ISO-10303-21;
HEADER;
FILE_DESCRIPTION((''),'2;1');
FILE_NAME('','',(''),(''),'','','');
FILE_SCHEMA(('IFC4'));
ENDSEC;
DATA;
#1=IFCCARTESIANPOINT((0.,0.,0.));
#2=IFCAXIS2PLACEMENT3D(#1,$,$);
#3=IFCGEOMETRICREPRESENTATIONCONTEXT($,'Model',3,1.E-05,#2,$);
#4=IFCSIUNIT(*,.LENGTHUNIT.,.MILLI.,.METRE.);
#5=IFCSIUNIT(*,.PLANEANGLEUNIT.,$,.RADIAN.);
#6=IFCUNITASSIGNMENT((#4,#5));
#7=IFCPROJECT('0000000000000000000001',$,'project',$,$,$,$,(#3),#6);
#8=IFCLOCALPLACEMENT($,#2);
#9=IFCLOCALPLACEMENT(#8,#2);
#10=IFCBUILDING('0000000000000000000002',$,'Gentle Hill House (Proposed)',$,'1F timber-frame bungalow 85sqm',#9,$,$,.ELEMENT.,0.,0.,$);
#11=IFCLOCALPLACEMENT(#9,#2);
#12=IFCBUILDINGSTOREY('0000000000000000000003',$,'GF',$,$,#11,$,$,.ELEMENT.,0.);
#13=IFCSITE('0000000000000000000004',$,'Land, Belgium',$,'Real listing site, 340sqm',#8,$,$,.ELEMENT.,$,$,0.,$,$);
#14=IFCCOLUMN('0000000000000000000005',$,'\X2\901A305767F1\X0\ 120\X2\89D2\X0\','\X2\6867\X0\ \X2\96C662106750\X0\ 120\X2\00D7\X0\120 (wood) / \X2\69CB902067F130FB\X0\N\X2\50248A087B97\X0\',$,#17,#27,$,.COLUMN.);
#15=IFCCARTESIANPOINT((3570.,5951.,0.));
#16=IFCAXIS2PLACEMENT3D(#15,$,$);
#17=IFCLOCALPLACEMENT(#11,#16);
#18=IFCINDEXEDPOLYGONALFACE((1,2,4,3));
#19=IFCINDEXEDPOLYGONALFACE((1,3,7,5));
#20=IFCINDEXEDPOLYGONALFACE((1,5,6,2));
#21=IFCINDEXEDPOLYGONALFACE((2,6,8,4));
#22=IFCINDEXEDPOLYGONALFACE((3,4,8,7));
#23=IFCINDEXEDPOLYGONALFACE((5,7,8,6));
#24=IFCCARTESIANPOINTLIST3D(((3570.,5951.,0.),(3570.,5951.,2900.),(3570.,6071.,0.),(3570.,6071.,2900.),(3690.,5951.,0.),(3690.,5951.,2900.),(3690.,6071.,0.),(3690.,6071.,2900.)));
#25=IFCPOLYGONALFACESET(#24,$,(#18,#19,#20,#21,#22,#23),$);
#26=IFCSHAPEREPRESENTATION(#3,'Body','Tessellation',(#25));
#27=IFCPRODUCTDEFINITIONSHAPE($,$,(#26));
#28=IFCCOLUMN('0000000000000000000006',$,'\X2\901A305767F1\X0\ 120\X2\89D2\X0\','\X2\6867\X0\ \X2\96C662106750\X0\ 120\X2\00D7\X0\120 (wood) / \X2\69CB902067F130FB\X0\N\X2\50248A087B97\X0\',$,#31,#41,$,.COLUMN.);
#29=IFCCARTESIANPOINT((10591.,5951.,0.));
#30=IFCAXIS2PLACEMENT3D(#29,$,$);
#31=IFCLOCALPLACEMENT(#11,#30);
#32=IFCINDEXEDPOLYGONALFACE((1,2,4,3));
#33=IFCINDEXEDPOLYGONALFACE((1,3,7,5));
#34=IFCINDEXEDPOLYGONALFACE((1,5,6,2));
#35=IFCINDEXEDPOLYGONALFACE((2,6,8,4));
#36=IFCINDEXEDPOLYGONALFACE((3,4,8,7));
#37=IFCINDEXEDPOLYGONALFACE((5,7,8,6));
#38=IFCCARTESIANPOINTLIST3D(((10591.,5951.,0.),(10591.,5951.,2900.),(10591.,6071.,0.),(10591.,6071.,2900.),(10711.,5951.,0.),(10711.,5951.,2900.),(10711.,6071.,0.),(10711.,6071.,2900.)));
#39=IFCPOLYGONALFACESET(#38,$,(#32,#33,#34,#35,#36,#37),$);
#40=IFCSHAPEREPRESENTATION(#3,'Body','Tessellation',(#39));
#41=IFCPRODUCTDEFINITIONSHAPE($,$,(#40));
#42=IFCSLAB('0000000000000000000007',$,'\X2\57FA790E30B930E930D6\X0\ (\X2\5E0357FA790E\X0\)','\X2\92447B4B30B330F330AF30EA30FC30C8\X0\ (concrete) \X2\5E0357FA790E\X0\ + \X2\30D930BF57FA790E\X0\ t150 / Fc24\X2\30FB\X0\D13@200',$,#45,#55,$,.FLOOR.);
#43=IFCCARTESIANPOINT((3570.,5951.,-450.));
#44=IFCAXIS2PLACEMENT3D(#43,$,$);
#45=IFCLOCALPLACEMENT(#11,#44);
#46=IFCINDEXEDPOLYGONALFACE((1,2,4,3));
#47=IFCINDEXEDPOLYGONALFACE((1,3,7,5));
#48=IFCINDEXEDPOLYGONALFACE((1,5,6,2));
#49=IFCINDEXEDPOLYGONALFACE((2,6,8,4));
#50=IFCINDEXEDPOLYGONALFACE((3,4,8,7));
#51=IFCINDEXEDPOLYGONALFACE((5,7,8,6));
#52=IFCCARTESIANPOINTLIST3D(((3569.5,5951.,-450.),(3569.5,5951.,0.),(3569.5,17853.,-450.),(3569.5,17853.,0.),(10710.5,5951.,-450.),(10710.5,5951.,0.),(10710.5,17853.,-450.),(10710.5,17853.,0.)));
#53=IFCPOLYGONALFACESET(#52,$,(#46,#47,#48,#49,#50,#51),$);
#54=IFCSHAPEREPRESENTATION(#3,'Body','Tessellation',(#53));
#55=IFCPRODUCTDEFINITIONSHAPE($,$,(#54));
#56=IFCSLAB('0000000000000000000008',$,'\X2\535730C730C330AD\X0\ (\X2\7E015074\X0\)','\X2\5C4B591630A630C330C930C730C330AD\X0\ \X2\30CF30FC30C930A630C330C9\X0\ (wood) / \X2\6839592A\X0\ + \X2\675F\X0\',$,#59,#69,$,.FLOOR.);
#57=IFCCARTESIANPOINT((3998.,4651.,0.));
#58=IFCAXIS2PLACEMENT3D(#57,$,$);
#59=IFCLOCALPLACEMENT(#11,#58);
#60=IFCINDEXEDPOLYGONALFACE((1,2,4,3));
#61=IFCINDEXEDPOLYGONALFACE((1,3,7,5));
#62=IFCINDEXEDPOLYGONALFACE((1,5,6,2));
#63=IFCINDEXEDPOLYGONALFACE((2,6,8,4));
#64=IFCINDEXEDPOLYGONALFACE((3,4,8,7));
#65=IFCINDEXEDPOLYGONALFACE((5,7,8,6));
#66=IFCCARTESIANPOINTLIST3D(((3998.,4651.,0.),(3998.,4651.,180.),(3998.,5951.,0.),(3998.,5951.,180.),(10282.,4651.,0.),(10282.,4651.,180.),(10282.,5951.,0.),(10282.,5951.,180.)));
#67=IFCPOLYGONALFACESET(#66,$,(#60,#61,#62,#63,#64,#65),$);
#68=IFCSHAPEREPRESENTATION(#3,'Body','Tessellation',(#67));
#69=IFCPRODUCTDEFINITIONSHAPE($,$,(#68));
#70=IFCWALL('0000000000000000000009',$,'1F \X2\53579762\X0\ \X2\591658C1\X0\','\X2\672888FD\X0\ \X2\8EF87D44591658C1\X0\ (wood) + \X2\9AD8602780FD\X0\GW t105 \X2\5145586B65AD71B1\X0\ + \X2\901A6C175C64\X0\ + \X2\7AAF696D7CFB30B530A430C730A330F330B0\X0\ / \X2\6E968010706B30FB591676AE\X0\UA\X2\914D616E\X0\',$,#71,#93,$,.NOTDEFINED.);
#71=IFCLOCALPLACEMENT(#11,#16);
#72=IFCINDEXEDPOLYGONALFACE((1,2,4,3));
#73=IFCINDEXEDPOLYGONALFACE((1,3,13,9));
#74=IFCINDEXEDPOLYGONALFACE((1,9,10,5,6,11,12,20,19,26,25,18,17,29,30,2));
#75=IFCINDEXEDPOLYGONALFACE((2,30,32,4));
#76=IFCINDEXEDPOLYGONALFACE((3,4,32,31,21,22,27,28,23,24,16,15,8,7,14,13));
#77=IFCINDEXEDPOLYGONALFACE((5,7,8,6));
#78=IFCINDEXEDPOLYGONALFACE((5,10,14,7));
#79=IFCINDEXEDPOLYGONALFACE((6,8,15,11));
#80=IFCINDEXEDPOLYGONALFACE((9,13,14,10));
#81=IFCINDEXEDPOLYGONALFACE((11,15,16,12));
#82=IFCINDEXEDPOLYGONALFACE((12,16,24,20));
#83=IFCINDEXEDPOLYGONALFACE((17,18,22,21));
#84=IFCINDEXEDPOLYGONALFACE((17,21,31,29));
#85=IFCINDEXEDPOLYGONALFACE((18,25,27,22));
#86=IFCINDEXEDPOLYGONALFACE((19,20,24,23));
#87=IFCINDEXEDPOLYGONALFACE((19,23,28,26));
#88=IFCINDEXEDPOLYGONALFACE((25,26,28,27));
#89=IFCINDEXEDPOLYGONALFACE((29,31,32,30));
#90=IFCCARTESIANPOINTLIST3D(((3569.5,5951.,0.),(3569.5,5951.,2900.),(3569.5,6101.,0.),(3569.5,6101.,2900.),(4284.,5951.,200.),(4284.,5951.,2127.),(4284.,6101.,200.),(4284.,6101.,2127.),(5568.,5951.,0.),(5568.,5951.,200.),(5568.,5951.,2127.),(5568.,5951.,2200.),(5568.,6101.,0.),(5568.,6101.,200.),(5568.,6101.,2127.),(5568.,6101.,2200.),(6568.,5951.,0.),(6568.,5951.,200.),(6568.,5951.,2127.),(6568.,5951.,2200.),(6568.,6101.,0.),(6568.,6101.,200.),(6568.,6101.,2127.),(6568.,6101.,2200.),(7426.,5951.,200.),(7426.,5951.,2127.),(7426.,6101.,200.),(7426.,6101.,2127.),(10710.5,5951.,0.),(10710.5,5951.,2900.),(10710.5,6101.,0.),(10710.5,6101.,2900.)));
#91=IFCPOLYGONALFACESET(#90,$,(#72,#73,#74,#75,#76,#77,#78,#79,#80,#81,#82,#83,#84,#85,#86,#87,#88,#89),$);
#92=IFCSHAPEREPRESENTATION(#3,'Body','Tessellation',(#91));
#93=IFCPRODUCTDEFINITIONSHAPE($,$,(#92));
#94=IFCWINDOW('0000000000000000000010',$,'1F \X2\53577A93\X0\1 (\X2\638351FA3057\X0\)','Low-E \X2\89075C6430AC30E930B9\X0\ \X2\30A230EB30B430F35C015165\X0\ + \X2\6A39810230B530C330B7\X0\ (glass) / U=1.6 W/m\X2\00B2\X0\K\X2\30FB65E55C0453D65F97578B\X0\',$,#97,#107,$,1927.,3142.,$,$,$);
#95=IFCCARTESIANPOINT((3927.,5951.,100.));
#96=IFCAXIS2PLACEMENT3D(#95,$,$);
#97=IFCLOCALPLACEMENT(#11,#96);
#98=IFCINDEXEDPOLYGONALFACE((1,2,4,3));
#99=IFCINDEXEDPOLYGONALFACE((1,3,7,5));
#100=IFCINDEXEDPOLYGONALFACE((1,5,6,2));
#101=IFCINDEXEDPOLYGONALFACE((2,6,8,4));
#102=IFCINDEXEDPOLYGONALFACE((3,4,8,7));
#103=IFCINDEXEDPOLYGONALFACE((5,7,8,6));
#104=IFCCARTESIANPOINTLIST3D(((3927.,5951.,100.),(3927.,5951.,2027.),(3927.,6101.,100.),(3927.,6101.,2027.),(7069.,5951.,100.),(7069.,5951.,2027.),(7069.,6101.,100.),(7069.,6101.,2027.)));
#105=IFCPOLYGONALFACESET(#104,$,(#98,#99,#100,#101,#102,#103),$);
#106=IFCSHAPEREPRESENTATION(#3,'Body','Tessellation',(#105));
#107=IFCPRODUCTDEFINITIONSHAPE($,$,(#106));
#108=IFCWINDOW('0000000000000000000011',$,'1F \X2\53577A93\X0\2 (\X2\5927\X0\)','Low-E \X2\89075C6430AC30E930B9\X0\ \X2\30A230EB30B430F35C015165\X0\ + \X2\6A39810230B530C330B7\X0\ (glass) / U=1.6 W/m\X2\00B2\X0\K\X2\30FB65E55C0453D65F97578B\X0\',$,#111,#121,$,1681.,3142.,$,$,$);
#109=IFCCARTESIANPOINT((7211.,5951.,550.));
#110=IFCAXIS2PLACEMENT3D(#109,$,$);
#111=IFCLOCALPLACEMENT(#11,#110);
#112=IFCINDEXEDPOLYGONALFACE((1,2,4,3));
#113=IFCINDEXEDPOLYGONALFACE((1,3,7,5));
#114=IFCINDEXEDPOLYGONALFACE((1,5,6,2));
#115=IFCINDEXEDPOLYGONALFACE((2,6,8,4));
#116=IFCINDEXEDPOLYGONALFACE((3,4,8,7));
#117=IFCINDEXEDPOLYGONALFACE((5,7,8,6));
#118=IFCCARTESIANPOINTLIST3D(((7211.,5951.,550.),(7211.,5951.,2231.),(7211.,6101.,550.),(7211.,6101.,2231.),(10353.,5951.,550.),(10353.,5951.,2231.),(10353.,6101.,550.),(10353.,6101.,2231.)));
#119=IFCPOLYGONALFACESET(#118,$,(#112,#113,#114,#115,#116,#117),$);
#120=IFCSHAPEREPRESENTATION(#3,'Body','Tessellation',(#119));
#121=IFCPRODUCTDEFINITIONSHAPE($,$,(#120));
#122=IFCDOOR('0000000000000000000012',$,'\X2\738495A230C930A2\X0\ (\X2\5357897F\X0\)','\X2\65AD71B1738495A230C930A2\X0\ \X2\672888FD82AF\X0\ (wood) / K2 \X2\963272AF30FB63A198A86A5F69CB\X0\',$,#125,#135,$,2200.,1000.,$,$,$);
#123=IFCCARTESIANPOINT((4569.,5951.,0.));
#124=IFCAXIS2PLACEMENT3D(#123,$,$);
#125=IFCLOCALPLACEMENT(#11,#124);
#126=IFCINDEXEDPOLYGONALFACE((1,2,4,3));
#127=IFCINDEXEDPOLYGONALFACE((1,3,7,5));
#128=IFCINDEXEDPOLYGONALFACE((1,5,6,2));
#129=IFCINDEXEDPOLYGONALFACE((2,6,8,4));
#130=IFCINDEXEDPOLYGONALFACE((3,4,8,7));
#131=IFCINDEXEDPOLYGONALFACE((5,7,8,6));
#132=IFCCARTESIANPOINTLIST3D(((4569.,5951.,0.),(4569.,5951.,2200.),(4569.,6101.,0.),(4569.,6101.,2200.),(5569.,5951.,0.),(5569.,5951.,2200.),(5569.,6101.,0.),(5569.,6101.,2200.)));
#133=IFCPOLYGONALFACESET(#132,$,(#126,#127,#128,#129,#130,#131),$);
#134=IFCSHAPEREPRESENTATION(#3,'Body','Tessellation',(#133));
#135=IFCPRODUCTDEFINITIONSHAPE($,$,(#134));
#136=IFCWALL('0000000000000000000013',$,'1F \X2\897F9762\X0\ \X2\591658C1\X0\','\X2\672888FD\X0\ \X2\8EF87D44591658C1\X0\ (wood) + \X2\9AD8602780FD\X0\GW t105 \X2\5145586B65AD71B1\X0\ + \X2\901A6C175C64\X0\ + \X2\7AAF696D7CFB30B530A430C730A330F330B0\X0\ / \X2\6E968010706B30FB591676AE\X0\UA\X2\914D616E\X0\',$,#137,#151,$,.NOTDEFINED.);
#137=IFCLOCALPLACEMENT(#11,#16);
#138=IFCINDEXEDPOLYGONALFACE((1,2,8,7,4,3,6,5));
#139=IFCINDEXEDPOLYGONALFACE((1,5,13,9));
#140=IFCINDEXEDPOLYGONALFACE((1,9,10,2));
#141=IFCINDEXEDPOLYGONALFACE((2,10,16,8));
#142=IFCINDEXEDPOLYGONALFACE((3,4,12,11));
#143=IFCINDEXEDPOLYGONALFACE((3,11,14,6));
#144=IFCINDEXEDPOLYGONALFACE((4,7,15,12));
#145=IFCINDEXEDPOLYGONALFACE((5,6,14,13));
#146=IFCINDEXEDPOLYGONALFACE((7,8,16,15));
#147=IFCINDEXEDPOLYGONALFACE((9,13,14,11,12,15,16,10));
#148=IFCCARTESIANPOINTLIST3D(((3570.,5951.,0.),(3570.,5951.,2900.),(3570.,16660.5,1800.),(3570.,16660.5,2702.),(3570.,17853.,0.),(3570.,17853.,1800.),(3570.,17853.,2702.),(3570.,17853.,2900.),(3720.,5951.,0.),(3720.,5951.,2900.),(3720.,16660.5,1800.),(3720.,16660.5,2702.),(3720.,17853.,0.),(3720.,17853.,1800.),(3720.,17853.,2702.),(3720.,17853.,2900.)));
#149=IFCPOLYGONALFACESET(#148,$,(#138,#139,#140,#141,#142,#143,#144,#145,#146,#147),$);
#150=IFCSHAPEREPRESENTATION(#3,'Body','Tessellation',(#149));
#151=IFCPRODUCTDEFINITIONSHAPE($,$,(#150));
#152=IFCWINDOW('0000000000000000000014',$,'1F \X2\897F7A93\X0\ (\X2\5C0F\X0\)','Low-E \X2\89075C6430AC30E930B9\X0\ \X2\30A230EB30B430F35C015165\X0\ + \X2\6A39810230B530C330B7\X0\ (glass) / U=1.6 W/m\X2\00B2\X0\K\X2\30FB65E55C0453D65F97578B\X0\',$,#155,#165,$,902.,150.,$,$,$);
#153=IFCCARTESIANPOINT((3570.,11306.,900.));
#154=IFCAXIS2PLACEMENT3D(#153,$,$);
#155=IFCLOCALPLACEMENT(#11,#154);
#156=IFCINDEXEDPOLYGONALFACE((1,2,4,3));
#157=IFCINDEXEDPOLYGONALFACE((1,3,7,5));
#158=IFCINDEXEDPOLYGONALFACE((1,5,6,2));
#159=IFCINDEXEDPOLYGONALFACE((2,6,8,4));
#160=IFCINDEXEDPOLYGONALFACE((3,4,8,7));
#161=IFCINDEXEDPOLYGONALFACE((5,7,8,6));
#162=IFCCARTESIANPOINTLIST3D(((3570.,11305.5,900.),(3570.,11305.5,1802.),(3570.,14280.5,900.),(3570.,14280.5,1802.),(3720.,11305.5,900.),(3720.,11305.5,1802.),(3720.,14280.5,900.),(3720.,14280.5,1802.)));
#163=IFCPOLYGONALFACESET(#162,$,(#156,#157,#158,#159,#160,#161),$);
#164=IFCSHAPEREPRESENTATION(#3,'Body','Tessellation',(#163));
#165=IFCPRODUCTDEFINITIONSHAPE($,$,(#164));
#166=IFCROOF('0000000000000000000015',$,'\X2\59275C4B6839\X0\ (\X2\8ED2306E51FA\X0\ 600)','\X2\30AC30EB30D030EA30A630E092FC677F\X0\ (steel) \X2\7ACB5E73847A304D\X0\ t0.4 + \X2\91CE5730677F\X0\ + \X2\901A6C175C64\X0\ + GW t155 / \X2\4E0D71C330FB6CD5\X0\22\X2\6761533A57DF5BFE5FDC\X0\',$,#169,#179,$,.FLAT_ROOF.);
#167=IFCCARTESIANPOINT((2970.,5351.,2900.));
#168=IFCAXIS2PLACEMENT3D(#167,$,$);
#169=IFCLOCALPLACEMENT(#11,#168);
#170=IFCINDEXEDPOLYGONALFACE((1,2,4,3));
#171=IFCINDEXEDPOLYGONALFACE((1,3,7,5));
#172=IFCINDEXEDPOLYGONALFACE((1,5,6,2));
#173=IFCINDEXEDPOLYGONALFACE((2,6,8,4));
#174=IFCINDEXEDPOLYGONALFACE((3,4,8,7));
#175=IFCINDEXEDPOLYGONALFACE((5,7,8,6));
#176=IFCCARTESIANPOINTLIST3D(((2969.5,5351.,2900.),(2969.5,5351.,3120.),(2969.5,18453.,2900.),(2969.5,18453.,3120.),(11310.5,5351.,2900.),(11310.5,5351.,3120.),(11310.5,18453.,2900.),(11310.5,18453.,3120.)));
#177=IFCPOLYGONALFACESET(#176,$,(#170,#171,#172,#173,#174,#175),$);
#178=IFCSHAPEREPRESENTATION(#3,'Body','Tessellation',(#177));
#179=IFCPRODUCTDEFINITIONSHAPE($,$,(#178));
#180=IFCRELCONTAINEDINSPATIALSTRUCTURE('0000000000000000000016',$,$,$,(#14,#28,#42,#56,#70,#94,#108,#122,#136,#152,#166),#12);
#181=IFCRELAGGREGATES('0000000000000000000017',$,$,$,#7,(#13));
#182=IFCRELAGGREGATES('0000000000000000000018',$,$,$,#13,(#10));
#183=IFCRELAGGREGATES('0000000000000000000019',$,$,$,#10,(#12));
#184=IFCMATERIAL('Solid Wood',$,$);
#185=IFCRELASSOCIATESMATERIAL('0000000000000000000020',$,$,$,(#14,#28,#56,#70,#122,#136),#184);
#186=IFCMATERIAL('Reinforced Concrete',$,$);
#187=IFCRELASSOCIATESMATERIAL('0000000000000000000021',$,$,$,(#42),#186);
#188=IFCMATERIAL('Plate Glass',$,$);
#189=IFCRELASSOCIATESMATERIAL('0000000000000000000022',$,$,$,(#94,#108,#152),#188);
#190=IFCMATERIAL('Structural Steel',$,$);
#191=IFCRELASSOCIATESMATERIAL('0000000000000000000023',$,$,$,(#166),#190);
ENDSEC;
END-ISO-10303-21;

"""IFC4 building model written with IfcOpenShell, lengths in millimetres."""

from ifc_helpers import new_model, si_unit, frame, frame_2d, origin, place, context, project, spatial, rectangle, extrude, material, element, fill, save


model = new_model("IFC4")

# Units and contexts
model_context = context("Model", 3, precision=1e-05, world=origin())
ifc_project = project(units=[si_unit("LENGTHUNIT", "METRE", prefix="MILLI"), si_unit("PLANEANGLEUNIT", "RADIAN")], contexts=[model_context])

# Site, building, storey
site_placement = place(None, origin())
site = spatial("IfcSite", under=ifc_project, at=site_placement, Name="Land, Belgium", ObjectType="Real listing site, 340sqm", CompositionType="ELEMENT", RefElevation=0.0)
building_placement = place(site_placement, origin())
building = spatial("IfcBuilding", under=site, at=building_placement, Name="Gentle Hill House (Proposed)", ObjectType="1F timber-frame bungalow 85sqm", CompositionType="ELEMENT", ElevationOfRefHeight=0.0, ElevationOfTerrain=0.0)
storey_placement = place(building_placement, origin())
storey = spatial("IfcBuildingStorey", under=building, at=storey_placement, Name="GF", CompositionType="ELEMENT", Elevation=0.0)

# Columns
ifc_material_1 = material(Name="Solid Wood")
column_1_placement = place(storey_placement, frame((3570.0, 5951.0, 0.0)))
element("IfcColumn", 1, at=column_1_placement, inside=storey, material=ifc_material_1, Name="通し柱 120角", Description="桧 集成材 120×120 (wood) / 構造柱・N値計算", PredefinedType="COLUMN", context=model_context, shape_type="SweptSolid", body=[
    extrude(rectangle(XDim=120.0, YDim=120.0, at=frame_2d((60.0, 60.0))), frame((3570.0, 5951.0, 0.0)), (0.0, 0.0, 1.0), 2900.0),
])
column_2_placement = place(storey_placement, frame((10591.0, 5951.0, 0.0)))
element("IfcColumn", 2, at=column_2_placement, inside=storey, material=ifc_material_1, Name="通し柱 120角", Description="桧 集成材 120×120 (wood) / 構造柱・N値計算", PredefinedType="COLUMN", context=model_context, shape_type="SweptSolid", body=[
    extrude(rectangle(XDim=120.0, YDim=120.0, at=frame_2d((60.0, 60.0))), frame((10591.0, 5951.0, 0.0)), (0.0, 0.0, 1.0), 2900.0),
])

# Slabs
ifc_material_2 = material(Name="Reinforced Concrete")
slab_1_placement = place(storey_placement, frame((3570.0, 5951.0, -450.0)))
element("IfcSlab", 3, at=slab_1_placement, inside=storey, material=ifc_material_2, Name="基礎スラブ (布基礎)", Description="鉄筋コンクリート (concrete) 布基礎 + ベタ基礎 t150 / Fc24・D13@200", PredefinedType="FLOOR", context=model_context, shape_type="SweptSolid", body=[
    extrude(rectangle(XDim=7141.0, YDim=11902.0, at=frame_2d((3570.0, 5951.0))), frame((3570.0, 5951.0, -450.0)), (0.0, 0.0, 1.0), 450.0),
])
slab_2_placement = place(storey_placement, frame((3998.0, 4651.0, 0.0)))
element("IfcSlab", 4, at=slab_2_placement, inside=storey, material=ifc_material_1, Name="南デッキ (縁側)", Description="屋外ウッドデッキ ハードウッド (wood) / 根太 + 束", PredefinedType="FLOOR", context=model_context, shape_type="SweptSolid", body=[
    extrude(rectangle(XDim=6284.0, YDim=1300.0, at=frame_2d((3142.0, 650.0))), frame((3998.0, 4651.0, 0.0)), (0.0, 0.0, 1.0), 180.0),
])

# Wall, openings, windows, door
wall_1_placement = place(storey_placement, frame((3570.0, 5951.0, 0.0)))
wall_1 = element("IfcWall", 5, at=wall_1_placement, inside=storey, material=ifc_material_1, Name="1F 南面 外壁", Description="木製 軸組外壁 (wood) + 高性能GW t105 充填断熱 + 通気層 + 窯業系サイディング / 準耐火・外皮UA配慮", PredefinedType="NOTDEFINED", context=model_context, shape_type="SweptSolid", body=[
    extrude(rectangle(XDim=7141.0, YDim=150.0, at=frame_2d((3570.0, 75.0))), frame((3570.0, 5951.0, 0.0)), (0.0, 0.0, 1.0), 2900.0),
])
opening_1_placement = place(storey_placement, frame((3927.0, 5951.0, 100.0)))
opening_1 = element("IfcOpeningElement", 6, at=opening_1_placement, cuts=wall_1, PredefinedType="NOTDEFINED", context=model_context, shape_type="SweptSolid", body=[
    extrude(rectangle(XDim=3142.0, YDim=150.0, at=frame_2d((1571.0, 75.0))), frame((3927.0, 5951.0, 100.0)), (0.0, 0.0, 1.0), 1927.0),
])
opening_2_placement = place(storey_placement, frame((7211.0, 5951.0, 550.0)))
opening_2 = element("IfcOpeningElement", 7, at=opening_2_placement, cuts=wall_1, PredefinedType="NOTDEFINED", context=model_context, shape_type="SweptSolid", body=[
    extrude(rectangle(XDim=3142.0, YDim=150.0, at=frame_2d((1571.0, 75.0))), frame((7211.0, 5951.0, 550.0)), (0.0, 0.0, 1.0), 1681.0),
])
opening_3_placement = place(storey_placement, frame((4569.0, 5951.0, 0.0)))
opening_3 = element("IfcOpeningElement", 8, at=opening_3_placement, cuts=wall_1, PredefinedType="NOTDEFINED", context=model_context, shape_type="SweptSolid", body=[
    extrude(rectangle(XDim=1000.0, YDim=150.0, at=frame_2d((500.0, 75.0))), frame((4569.0, 5951.0, 0.0)), (0.0, 0.0, 1.0), 2200.0),
])
ifc_material_3 = material(Name="Plate Glass")
window_1_placement = place(storey_placement, frame((3927.0, 5951.0, 100.0)))
window_1 = element("IfcWindow", 9, at=window_1_placement, inside=storey, material=ifc_material_3, Name="1F 南窓1 (掃出し)", Description="Low-E 複層ガラス アルゴン封入 + 樹脂サッシ (glass) / U=1.6 W/m²K・日射取得型", OverallHeight=1927.0, OverallWidth=3142.0, context=model_context, shape_type="SweptSolid", body=[
    extrude(rectangle(XDim=3142.0, YDim=150.0, at=frame_2d((1571.0, 75.0))), frame((3927.0, 5951.0, 100.0)), (0.0, 0.0, 1.0), 1927.0),
])
fill(opening_1, window_1)
window_2_placement = place(storey_placement, frame((7211.0, 5951.0, 550.0)))
window_2 = element("IfcWindow", 10, at=window_2_placement, inside=storey, material=ifc_material_3, Name="1F 南窓2 (大)", Description="Low-E 複層ガラス アルゴン封入 + 樹脂サッシ (glass) / U=1.6 W/m²K・日射取得型", OverallHeight=1681.0, OverallWidth=3142.0, context=model_context, shape_type="SweptSolid", body=[
    extrude(rectangle(XDim=3142.0, YDim=150.0, at=frame_2d((1571.0, 75.0))), frame((7211.0, 5951.0, 550.0)), (0.0, 0.0, 1.0), 1681.0),
])
fill(opening_2, window_2)
door_placement = place(storey_placement, frame((4569.0, 5951.0, 0.0)))
door = element("IfcDoor", 11, at=door_placement, inside=storey, material=ifc_material_1, Name="玄関ドア (南西)", Description="断熱玄関ドア 木製芯 (wood) / K2 防犯・採風機構", OverallHeight=2200.0, OverallWidth=1000.0, context=model_context, shape_type="SweptSolid", body=[
    extrude(rectangle(XDim=1000.0, YDim=150.0, at=frame_2d((500.0, 75.0))), frame((4569.0, 5951.0, 0.0)), (0.0, 0.0, 1.0), 2200.0),
])
fill(opening_3, door)

# Wall, opening, window
wall_2_placement = place(storey_placement, frame((3570.0, 5951.0, 0.0)))
wall_2 = element("IfcWall", 12, at=wall_2_placement, inside=storey, material=ifc_material_1, Name="1F 西面 外壁", Description="木製 軸組外壁 (wood) + 高性能GW t105 充填断熱 + 通気層 + 窯業系サイディング / 準耐火・外皮UA配慮", PredefinedType="NOTDEFINED", context=model_context, shape_type="SweptSolid", body=[
    extrude(rectangle(XDim=150.0, YDim=11902.0, at=frame_2d((75.0, 5951.0))), frame((3570.0, 5951.0, 0.0)), (0.0, 0.0, 1.0), 2900.0),
])
opening_4_placement = place(storey_placement, frame((3570.0, 11306.0, 900.0)))
opening_4 = element("IfcOpeningElement", 13, at=opening_4_placement, cuts=wall_2, PredefinedType="NOTDEFINED", context=model_context, shape_type="SweptSolid", body=[
    extrude(rectangle(XDim=150.0, YDim=2975.0, at=frame_2d((75.0, 1487.0))), frame((3570.0, 11306.0, 900.0)), (0.0, 0.0, 1.0), 902.0),
])
window_3_placement = place(storey_placement, frame((3570.0, 11306.0, 900.0)))
window_3 = element("IfcWindow", 14, at=window_3_placement, inside=storey, material=ifc_material_3, Name="1F 西窓 (小)", Description="Low-E 複層ガラス アルゴン封入 + 樹脂サッシ (glass) / U=1.6 W/m²K・日射取得型", OverallHeight=902.0, OverallWidth=150.0, context=model_context, shape_type="SweptSolid", body=[
    extrude(rectangle(XDim=150.0, YDim=2975.0, at=frame_2d((75.0, 1487.0))), frame((3570.0, 11306.0, 900.0)), (0.0, 0.0, 1.0), 902.0),
])
fill(opening_4, window_3)

# Roof
ifc_material_4 = material(Name="Structural Steel")
roof_placement = place(storey_placement, frame((2970.0, 5351.0, 2900.0)))
element("IfcRoof", 15, at=roof_placement, inside=storey, material=ifc_material_4, Name="大屋根 (軒の出 600)", Description="ガルバリウム鋼板 (steel) 立平葺き t0.4 + 野地板 + 通気層 + GW t155 / 不燃・法22条区域対応", PredefinedType="FLAT_ROOF", context=model_context, shape_type="SweptSolid", body=[
    extrude(rectangle(XDim=8341.0, YDim=13102.0, at=frame_2d((4170.0, 6551.0))), frame((2970.0, 5351.0, 2900.0)), (0.0, 0.0, 1.0), 220.0),
])

save(model, "model.ifc")
